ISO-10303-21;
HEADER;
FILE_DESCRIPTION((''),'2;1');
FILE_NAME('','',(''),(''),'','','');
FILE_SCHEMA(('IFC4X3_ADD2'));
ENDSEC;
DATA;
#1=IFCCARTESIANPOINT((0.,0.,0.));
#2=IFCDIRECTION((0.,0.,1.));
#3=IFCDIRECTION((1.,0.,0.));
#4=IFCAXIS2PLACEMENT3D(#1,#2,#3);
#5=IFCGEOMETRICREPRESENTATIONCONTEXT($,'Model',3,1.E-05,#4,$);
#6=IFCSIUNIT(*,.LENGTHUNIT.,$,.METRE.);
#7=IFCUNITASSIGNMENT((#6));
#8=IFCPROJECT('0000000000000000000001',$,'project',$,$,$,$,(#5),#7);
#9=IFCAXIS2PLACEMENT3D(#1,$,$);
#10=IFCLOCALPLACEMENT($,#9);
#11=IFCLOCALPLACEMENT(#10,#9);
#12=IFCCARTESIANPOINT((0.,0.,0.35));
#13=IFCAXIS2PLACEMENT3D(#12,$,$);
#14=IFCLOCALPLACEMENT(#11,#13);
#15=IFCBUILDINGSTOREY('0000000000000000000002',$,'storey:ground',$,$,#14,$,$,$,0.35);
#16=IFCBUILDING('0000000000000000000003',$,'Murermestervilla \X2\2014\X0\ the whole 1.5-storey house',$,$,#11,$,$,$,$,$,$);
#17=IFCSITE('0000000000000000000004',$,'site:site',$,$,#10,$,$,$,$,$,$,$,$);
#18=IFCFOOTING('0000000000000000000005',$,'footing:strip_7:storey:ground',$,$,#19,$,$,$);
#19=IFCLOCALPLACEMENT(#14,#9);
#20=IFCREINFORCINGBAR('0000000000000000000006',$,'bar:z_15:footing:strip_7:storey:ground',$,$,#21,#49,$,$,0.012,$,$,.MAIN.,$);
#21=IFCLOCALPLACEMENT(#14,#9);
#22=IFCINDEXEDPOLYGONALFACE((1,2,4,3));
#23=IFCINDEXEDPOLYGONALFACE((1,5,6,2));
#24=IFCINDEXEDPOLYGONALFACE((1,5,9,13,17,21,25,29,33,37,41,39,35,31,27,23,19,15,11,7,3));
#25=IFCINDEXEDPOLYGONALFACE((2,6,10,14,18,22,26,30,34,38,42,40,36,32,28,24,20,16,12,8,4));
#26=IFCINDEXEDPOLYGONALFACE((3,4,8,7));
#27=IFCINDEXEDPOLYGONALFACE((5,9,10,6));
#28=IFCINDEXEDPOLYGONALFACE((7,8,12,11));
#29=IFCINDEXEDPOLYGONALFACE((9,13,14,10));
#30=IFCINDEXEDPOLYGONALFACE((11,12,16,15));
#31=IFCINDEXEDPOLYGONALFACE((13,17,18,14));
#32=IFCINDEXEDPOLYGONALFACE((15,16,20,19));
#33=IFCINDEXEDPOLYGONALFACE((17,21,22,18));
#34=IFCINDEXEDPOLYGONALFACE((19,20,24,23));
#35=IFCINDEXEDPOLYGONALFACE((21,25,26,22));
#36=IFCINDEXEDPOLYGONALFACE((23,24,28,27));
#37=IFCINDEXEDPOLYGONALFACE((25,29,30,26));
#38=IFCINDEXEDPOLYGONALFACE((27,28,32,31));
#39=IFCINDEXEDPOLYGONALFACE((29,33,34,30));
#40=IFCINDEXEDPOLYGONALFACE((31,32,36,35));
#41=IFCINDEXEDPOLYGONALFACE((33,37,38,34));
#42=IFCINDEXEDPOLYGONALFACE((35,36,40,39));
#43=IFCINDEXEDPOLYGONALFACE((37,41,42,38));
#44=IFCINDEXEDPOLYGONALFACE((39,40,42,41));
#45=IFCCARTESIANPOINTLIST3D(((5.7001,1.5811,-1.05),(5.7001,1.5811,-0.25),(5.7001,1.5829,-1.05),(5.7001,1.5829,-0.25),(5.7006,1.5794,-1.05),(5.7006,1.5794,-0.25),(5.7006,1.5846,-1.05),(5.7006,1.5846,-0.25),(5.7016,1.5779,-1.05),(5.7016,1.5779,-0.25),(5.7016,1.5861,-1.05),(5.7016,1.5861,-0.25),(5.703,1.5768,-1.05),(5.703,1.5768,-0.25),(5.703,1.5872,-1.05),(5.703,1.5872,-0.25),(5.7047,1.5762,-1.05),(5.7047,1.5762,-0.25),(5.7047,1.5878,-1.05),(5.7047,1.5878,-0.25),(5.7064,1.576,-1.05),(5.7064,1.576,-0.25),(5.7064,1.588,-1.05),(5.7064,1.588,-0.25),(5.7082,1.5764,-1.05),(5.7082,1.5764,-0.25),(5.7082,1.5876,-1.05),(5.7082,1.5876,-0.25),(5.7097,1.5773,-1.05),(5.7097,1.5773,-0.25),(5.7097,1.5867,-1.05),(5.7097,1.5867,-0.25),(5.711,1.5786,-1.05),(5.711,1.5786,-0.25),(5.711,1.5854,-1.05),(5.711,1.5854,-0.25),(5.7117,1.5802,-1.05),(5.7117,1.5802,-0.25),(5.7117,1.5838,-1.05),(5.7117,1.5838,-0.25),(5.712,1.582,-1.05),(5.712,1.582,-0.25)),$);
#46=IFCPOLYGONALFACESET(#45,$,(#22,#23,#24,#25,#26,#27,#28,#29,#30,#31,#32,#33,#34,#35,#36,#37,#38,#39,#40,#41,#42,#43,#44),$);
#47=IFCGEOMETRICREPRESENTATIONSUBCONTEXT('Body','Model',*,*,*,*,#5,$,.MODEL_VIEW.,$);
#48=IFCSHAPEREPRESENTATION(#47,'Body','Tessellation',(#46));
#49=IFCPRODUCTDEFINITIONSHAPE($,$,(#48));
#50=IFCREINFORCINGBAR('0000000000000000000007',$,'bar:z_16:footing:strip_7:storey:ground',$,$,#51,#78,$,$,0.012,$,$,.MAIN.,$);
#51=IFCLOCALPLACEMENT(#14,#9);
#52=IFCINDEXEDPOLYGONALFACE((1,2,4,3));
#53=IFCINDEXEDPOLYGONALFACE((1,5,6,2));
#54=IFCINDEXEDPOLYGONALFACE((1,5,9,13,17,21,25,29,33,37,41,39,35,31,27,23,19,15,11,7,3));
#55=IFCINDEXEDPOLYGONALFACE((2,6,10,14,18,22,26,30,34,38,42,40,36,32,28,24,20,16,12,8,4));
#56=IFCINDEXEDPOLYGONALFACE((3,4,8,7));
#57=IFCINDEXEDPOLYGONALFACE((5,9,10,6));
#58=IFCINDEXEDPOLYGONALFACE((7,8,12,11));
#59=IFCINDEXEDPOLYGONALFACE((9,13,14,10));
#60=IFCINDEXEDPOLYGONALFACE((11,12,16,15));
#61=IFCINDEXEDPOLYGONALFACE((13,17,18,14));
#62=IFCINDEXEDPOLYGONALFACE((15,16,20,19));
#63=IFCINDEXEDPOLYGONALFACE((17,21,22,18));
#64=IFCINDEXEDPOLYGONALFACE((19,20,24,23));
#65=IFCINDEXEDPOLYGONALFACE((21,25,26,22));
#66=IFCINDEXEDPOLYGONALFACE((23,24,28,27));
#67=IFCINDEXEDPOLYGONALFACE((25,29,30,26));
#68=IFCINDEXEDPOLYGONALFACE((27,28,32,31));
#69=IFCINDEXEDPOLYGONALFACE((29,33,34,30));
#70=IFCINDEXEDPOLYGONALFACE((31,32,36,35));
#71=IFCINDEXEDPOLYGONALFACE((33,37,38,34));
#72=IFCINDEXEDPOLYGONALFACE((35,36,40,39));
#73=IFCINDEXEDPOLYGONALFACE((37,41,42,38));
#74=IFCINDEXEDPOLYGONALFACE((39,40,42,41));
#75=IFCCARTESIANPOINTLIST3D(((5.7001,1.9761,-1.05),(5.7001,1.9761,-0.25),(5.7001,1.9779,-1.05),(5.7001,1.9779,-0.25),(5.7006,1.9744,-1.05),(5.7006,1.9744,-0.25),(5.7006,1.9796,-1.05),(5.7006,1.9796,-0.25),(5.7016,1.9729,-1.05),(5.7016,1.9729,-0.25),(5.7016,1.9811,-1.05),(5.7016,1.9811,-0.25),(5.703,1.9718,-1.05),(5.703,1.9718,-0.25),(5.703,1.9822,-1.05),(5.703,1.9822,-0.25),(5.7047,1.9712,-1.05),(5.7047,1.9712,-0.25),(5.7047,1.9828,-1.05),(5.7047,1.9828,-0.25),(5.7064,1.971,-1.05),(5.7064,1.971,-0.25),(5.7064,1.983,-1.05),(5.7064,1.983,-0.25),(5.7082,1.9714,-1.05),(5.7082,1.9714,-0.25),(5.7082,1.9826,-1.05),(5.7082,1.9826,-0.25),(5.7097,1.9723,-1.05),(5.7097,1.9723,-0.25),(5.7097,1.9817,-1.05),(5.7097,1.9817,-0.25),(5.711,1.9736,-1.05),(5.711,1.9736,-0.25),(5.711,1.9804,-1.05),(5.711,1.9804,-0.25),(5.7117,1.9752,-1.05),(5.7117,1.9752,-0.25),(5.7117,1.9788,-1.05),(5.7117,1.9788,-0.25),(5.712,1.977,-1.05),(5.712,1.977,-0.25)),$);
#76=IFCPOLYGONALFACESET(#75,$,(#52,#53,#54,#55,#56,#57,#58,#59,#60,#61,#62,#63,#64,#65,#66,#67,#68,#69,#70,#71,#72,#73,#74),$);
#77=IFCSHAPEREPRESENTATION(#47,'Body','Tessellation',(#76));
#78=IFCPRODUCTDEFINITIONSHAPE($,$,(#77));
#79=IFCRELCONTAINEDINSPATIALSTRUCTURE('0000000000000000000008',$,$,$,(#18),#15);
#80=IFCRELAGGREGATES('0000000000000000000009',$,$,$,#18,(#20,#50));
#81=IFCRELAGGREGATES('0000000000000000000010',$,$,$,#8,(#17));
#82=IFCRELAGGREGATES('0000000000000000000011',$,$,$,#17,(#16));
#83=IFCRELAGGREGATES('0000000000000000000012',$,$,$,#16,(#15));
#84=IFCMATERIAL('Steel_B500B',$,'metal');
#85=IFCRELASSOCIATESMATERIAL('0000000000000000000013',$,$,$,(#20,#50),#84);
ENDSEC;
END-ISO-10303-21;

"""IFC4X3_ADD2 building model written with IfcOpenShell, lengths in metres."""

from ifc_helpers import new_model, entity, si_unit, frame, origin, origin_with_axes, place, context, subcontext, project, spatial, material, element, aggregate, save


model = new_model("IFC4X3_ADD2")

# Units and contexts
model_context = context("Model", 3, precision=1e-05, world=origin_with_axes())
body_context = subcontext(model_context, "Body", "Model", "MODEL_VIEW")
ifc_project = project(units=[si_unit("LENGTHUNIT", "METRE")], contexts=[model_context])

# Site, building, storey
placement_1 = place(None, origin())
site = spatial("IfcSite", under=ifc_project, at=placement_1, Name="site:site")
building_placement = place(placement_1, origin())
building = spatial("IfcBuilding", under=site, at=building_placement, Name="Murermestervilla — the whole 1.5-storey house")
storey_placement = place(building_placement, frame((0.0, 0.0, 0.35)))
storey = spatial("IfcBuildingStorey", under=building, at=storey_placement, Name="storey:ground", Elevation=0.35)

# Footing, reinforcing bars
placement_2 = place(storey_placement, frame((0.0, 0.0, -0.35)))
ifc_material = material(Name="Steel_B500B", Category="metal")
footing_1 = element("IfcFooting", 1, at=placement_2, inside=storey, Name="footing:strip_7:storey:ground")
reinforcing_bar_1 = element("IfcReinforcingBar", 2, at=placement_1, material=ifc_material, Name="bar:z_15:footing:strip_7:storey:ground", NominalDiameter=0.012, PredefinedType="MAIN", context=body_context, shape_type="AdvancedSweptSolid", body=[
    entity("IfcSweptDiskSolid", entity("IfcPolyline", [entity("IfcCartesianPoint", [5.706, 1.582, -0.7]), entity("IfcCartesianPoint", [5.706, 1.582, 0.1])]), 0.006),
])
reinforcing_bar_2 = element("IfcReinforcingBar", 3, at=placement_1, material=ifc_material, Name="bar:z_16:footing:strip_7:storey:ground", NominalDiameter=0.012, PredefinedType="MAIN", context=body_context, shape_type="AdvancedSweptSolid", body=[
    entity("IfcSweptDiskSolid", entity("IfcPolyline", [entity("IfcCartesianPoint", [5.706, 1.977, -0.7]), entity("IfcCartesianPoint", [5.706, 1.977, 0.1])]), 0.006),
])
aggregate(footing_1, [reinforcing_bar_1, reinforcing_bar_2])

save(model, "model.ifc")
